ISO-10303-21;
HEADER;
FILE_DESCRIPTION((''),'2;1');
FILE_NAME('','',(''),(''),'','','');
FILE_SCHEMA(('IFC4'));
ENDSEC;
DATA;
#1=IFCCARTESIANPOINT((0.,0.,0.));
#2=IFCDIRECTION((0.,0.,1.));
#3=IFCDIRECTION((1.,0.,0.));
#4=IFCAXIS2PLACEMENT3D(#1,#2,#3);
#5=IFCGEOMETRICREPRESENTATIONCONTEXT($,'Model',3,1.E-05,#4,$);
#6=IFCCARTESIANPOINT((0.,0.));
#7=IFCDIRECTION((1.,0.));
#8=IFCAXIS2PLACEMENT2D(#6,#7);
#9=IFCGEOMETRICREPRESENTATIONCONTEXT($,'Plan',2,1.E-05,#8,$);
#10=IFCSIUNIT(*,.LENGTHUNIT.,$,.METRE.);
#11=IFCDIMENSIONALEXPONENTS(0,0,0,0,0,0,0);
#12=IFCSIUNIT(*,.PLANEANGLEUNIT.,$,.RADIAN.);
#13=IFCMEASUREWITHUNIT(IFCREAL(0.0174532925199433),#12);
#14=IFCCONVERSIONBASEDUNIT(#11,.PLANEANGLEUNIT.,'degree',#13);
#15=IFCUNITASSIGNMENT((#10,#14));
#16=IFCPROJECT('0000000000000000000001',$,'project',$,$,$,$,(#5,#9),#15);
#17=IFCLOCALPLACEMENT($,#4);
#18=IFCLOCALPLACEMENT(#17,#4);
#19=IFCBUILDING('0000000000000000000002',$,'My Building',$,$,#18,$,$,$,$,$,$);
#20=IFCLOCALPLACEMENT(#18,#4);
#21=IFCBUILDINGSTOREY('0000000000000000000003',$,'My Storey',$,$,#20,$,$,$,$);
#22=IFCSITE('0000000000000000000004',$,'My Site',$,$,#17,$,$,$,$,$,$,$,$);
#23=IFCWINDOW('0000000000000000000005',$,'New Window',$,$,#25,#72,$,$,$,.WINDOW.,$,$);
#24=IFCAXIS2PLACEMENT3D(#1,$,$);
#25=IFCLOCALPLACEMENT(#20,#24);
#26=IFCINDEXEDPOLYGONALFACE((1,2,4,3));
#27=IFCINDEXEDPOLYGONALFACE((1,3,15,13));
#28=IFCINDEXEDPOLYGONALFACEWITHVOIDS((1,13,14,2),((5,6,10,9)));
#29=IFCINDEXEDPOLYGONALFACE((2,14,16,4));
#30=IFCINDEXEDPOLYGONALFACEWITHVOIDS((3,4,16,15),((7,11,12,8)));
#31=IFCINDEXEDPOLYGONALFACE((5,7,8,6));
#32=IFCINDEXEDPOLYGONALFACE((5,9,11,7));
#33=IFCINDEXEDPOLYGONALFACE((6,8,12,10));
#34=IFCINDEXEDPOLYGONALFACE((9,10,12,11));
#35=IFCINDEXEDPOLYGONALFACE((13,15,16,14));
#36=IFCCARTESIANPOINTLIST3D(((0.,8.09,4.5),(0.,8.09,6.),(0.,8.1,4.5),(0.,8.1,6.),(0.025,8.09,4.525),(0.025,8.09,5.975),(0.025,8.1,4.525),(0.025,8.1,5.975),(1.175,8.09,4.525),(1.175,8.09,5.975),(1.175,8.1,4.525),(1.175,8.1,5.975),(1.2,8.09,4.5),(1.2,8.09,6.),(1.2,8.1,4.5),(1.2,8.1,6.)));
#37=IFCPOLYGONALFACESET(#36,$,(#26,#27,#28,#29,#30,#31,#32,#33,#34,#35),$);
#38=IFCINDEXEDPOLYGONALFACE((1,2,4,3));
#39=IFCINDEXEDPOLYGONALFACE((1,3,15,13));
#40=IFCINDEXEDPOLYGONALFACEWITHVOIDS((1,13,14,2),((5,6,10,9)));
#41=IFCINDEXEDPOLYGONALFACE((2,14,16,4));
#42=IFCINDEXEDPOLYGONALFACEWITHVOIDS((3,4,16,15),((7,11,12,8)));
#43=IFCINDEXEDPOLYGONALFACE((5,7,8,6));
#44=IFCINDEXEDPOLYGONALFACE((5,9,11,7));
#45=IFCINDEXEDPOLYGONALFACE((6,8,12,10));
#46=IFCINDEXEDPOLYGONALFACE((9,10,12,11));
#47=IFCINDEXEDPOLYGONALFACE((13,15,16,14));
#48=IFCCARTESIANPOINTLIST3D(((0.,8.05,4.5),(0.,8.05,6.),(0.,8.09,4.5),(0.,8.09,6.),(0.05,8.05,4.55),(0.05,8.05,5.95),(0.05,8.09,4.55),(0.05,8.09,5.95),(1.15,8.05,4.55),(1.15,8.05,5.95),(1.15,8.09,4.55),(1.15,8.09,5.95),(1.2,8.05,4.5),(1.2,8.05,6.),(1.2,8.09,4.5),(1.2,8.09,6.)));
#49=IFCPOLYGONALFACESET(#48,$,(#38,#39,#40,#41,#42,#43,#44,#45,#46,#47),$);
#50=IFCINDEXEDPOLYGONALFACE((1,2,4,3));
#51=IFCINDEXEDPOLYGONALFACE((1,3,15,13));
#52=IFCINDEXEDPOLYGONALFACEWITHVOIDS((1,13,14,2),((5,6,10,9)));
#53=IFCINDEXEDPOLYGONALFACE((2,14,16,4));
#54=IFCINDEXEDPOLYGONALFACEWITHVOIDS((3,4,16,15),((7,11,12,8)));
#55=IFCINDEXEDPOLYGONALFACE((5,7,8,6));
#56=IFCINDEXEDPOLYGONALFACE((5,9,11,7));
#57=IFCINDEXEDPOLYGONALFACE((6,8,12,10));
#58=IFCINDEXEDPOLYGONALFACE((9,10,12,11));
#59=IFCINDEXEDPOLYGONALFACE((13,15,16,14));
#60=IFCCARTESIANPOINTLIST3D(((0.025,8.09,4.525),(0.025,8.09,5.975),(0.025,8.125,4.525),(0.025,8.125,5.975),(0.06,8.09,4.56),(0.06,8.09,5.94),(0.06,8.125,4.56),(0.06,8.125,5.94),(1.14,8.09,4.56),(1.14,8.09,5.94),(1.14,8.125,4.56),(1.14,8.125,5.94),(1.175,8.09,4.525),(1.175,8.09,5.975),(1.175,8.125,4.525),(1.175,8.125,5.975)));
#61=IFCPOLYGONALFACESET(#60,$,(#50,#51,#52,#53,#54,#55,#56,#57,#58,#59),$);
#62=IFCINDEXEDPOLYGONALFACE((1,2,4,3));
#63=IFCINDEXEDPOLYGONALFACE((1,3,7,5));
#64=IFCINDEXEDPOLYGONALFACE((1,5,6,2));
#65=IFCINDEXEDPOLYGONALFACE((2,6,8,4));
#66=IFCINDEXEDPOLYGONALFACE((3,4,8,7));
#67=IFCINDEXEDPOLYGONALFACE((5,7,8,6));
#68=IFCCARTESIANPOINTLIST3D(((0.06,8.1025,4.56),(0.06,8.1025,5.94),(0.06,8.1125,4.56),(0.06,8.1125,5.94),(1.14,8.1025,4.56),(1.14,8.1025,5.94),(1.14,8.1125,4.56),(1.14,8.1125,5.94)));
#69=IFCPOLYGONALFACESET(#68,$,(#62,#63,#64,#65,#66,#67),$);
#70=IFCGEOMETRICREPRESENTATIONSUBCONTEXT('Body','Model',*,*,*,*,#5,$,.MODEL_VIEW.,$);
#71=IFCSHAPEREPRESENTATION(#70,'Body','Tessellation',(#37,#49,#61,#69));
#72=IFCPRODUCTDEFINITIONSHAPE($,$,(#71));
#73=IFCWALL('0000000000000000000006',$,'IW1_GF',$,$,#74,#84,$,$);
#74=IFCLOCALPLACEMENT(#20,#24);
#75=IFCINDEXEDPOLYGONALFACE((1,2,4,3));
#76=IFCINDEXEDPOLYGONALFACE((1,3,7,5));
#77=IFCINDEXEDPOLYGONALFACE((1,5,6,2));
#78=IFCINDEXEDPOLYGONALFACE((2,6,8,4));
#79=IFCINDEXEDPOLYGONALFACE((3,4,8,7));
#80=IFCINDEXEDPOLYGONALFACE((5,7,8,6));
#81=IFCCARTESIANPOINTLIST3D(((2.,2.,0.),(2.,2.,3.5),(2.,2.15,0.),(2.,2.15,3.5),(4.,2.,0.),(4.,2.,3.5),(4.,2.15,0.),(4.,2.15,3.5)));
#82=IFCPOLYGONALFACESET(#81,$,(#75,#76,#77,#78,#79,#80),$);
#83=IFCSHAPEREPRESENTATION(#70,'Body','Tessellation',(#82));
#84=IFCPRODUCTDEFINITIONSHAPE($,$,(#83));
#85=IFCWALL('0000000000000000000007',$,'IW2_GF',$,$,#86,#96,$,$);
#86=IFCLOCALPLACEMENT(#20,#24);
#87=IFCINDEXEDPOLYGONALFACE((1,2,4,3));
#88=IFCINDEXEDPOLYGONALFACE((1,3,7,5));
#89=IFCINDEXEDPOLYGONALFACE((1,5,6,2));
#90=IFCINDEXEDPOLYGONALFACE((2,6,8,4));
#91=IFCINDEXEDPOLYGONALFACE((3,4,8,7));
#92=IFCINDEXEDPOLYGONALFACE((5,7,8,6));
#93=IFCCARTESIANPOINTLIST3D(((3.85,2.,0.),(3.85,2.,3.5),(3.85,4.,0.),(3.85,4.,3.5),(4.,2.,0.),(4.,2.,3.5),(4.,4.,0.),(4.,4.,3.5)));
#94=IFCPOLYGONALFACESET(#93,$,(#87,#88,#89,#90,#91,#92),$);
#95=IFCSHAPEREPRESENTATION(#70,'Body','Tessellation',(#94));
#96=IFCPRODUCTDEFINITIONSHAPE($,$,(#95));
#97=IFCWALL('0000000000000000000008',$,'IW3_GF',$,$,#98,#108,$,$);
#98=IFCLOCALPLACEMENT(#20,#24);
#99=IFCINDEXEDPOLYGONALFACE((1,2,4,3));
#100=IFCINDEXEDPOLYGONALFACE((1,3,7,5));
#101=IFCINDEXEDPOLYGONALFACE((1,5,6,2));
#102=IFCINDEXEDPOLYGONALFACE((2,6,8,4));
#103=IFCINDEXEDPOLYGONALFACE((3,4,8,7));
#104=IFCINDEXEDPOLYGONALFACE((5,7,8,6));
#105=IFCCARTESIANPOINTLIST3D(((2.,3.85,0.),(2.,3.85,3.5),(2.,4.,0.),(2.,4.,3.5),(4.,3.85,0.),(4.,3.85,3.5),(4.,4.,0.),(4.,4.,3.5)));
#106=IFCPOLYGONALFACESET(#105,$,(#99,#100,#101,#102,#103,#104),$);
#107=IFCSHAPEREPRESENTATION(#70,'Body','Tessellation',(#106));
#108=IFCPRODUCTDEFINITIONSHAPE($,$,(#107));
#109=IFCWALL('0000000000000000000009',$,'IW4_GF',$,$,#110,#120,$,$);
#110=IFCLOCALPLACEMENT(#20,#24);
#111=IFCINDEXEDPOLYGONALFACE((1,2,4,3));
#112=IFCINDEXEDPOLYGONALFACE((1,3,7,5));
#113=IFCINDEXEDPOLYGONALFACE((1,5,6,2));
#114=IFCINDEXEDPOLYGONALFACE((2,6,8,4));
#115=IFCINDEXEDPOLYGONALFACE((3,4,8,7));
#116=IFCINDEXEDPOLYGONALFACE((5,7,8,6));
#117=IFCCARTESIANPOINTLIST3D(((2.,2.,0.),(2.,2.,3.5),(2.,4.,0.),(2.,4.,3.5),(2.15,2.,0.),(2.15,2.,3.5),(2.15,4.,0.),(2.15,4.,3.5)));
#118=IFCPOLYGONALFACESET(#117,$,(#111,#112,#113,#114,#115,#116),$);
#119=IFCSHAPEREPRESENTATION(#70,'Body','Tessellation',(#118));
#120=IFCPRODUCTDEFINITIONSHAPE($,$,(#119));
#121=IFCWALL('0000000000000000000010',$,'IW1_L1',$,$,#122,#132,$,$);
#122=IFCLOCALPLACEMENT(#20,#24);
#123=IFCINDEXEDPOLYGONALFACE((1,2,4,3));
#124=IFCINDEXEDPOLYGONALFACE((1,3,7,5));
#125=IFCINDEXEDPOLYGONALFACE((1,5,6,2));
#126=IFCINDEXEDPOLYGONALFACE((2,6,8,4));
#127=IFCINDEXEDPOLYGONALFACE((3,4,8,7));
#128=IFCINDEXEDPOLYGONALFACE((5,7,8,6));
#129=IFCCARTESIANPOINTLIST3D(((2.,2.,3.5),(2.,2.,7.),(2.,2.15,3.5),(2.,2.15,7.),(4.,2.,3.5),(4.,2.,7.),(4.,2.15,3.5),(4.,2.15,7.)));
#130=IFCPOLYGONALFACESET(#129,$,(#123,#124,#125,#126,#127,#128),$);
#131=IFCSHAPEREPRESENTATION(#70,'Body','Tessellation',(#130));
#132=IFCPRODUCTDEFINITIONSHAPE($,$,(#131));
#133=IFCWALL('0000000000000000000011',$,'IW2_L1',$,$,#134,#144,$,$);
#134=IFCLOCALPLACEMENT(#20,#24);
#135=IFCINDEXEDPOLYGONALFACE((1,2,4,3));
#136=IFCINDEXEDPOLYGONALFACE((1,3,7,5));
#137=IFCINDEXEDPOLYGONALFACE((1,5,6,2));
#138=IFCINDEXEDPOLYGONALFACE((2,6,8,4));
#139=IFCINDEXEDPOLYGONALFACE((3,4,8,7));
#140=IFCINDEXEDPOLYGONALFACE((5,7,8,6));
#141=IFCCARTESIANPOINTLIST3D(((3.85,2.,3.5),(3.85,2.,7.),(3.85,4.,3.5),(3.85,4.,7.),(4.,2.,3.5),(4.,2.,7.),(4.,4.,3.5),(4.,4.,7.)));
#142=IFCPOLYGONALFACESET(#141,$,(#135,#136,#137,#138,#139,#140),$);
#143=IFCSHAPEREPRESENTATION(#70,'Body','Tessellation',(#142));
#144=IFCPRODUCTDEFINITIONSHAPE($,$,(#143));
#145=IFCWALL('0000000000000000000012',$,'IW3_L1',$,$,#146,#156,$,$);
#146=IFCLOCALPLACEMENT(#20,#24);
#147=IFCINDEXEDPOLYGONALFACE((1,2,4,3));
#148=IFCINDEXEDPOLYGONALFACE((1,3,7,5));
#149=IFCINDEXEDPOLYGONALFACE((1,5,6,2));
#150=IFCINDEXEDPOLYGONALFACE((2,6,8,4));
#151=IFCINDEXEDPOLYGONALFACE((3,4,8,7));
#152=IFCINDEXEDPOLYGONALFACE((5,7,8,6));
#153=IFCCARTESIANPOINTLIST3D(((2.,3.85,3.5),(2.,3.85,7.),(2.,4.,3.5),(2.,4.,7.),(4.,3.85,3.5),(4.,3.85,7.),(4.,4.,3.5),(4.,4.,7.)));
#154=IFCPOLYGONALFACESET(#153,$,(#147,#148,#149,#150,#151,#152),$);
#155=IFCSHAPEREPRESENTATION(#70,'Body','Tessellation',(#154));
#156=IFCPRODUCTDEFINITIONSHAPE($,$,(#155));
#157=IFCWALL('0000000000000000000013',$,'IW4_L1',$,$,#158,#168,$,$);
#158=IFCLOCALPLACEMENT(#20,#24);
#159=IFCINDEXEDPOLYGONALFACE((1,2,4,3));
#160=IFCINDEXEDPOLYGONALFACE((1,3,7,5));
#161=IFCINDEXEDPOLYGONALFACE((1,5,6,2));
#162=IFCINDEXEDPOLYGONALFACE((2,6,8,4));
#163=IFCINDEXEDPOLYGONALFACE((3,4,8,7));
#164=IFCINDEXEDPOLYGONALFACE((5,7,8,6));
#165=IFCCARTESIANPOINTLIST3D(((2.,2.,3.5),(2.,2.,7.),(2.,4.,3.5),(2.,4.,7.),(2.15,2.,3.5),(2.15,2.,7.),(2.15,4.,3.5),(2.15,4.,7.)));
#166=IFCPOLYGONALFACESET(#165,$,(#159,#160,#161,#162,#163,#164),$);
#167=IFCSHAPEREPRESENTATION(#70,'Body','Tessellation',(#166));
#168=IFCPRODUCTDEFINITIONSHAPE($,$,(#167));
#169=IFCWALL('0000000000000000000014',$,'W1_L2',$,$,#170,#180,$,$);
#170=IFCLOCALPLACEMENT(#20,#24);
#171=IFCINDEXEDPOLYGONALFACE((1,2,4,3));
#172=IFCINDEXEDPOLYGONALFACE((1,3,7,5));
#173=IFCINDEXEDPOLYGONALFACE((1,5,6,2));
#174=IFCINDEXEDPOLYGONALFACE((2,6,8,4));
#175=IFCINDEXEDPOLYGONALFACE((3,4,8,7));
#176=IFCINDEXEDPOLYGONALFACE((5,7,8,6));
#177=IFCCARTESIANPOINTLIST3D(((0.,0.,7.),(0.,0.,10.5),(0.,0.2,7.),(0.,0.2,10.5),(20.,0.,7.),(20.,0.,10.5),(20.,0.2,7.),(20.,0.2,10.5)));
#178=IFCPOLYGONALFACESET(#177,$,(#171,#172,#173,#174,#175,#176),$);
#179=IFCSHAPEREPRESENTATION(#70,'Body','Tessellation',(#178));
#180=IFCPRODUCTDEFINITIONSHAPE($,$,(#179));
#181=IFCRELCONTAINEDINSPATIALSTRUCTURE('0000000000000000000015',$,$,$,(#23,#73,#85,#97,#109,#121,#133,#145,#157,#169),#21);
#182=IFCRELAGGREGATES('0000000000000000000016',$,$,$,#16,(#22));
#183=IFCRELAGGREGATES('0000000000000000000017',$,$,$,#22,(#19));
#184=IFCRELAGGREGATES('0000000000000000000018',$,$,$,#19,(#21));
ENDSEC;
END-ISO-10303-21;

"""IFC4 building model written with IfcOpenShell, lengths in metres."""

from ifc_helpers import new_model, entity, si_unit, converted_unit, frame, origin_with_axes, origin_2d_with_axis, place, context, subcontext, project, spatial, line, indexed_curve, outline, extrude, element, save


model = new_model("IFC4")

# Units and contexts
model_context = context("Model", 3, precision=1e-05, world=origin_with_axes())
plan_context = context("Plan", 2, precision=1e-05, world=origin_2d_with_axis())
body_context = subcontext(model_context, "Body", "Model", "MODEL_VIEW")
ifc_project = project(units=[si_unit("LENGTHUNIT", "METRE"), converted_unit("PLANEANGLEUNIT", "degree", entity("IfcReal", 0.0174532925199433), si_unit("PLANEANGLEUNIT", "RADIAN"), dimensions=[0, 0, 0, 0, 0, 0, 0])], contexts=[model_context, plan_context])

# Site, building, storey
site_placement = place(None, origin_with_axes())
site = spatial("IfcSite", under=ifc_project, at=site_placement, Name="My Site")
building_placement = place(site_placement, origin_with_axes())
building = spatial("IfcBuilding", under=site, at=building_placement, Name="My Building")
storey_placement = place(building_placement, origin_with_axes())
storey = spatial("IfcBuildingStorey", under=building, at=storey_placement, Name="My Storey")

# Window
for number, where, z_axis, x_axis, name in (
    (1, (0.0, 8.0, 4.5), (0.0, 0.0, 1.0), (1.0, 0.0, 0.0), "New Window"),
):
    element("IfcWindow", number, at=place(storey_placement, frame(where, z_axis=z_axis, x_axis=x_axis)), inside=storey, Name=name, PredefinedType="WINDOW", context=body_context, shape_type="SweptSolid", body=[
        extrude(outline(indexed_curve([(0.0, 0.0), (1.2, 0.0), (1.2, 1.5), (0.0, 1.5)], segments=[line(1, 2, 3, 4, 1)]), holes=[indexed_curve([(0.025, 0.025), (1.175, 0.025), (1.175, 1.475), (0.025, 1.475)], segments=[line(1, 2, 3, 4, 1)])]), frame((0.0, 0.09, 0.0), z_axis=(0.0, -1.0, 0.0), x_axis=(1.0, 0.0, 0.0)), (0.0, 0.0, -1.0), 0.01),
        extrude(outline(indexed_curve([(0.0, 0.0), (1.2, 0.0), (1.2, 1.5), (0.0, 1.5)], segments=[line(1, 2, 3, 4, 1)]), holes=[indexed_curve([(0.05, 0.05), (1.15, 0.05), (1.15, 1.45), (0.05, 1.45)], segments=[line(1, 2, 3, 4, 1)])]), frame((0.0, 0.05, 0.0), z_axis=(0.0, -1.0, 0.0), x_axis=(1.0, 0.0, 0.0)), (0.0, 0.0, -1.0), 0.04),
        extrude(outline(indexed_curve([(0.0, 0.0), (1.15, 0.0), (1.15, 1.45), (0.0, 1.45)], segments=[line(1, 2, 3, 4, 1)]), holes=[indexed_curve([(0.035, 0.035), (1.115, 0.035), (1.115, 1.415), (0.035, 1.415)], segments=[line(1, 2, 3, 4, 1)])]), frame((0.025, 0.09, 0.025), z_axis=(0.0, -1.0, 0.0), x_axis=(1.0, 0.0, 0.0)), (0.0, 0.0, -1.0), 0.035),
        extrude(outline(indexed_curve([(0.035, 0.035), (1.115, 0.035), (1.115, 1.415), (0.035, 1.415)], segments=[line(1, 2, 3, 4, 1)])), frame((0.025, 0.1025, 0.025), z_axis=(0.0, -1.0, 0.0), x_axis=(1.0, 0.0, 0.0)), (0.0, 0.0, -1.0), 0.01),
    ])

# Walls
for number, where, z_axis, x_axis, name in (
    (2, (2.0, 2.0, 0.0), (0.0, 0.0, 1.0), (1.0, 0.0, 0.0), "IW1_GF"),
    (3, (4.0, 2.0, 0.0), (0.0, 0.0, 1.0), (0.0, 1.0, 0.0), "IW2_GF"),
    (4, (4.0, 4.0, 0.0), (0.0, 0.0, 1.0), (-1.0, 0.0, 0.0), "IW3_GF"),
    (5, (2.0, 4.0, 0.0), (0.0, 0.0, 1.0), (0.0, -1.0, 0.0), "IW4_GF"),
):
    element("IfcWall", number, at=place(storey_placement, frame(where, z_axis=z_axis, x_axis=x_axis)), inside=storey, Name=name, context=body_context, shape_type="SweptSolid", body=[
        extrude(outline(indexed_curve([(0.0, 0.0), (0.0, 0.15), (2.0, 0.15), (2.0, 0.0), (0.0, 0.0)], self_intersect=False)), origin_with_axes(), (0.0, 0.0, 1.0), 3.5),
    ])
for number, where, z_axis, x_axis, name in (
    (6, (2.0, 2.0, 3.5), (0.0, 0.0, 1.0), (1.0, 0.0, 0.0), "IW1_L1"),
    (7, (4.0, 2.0, 3.5), (0.0, 0.0, 1.0), (0.0, 1.0, 0.0), "IW2_L1"),
    (8, (4.0, 4.0, 3.5), (0.0, 0.0, 1.0), (-1.0, 0.0, 0.0), "IW3_L1"),
    (9, (2.0, 4.0, 3.5), (0.0, 0.0, 1.0), (0.0, -1.0, 0.0), "IW4_L1"),
):
    element("IfcWall", number, at=place(storey_placement, frame(where, z_axis=z_axis, x_axis=x_axis)), inside=storey, Name=name, context=body_context, shape_type="SweptSolid", body=[
        extrude(outline(indexed_curve([(0.0, 0.0), (0.0, 0.15), (2.0, 0.15), (2.0, 0.0), (0.0, 0.0)], self_intersect=False)), origin_with_axes(), (0.0, 0.0, 1.0), 3.5),
    ])
wall_1_placement = place(storey_placement, frame((0.0, 0.0, 7.0), z_axis=(0.0, 0.0, 1.0), x_axis=(1.0, 0.0, 0.0)))
element("IfcWall", 10, at=wall_1_placement, inside=storey, Name="W1_L2", context=body_context, shape_type="SweptSolid", body=[
    extrude(outline(indexed_curve([(0.0, 0.0), (0.0, 0.2), (20.0, 0.2), (20.0, 0.0), (0.0, 0.0)], self_intersect=False)), origin_with_axes(), (0.0, 0.0, 1.0), 3.5),
])

save(model, "model.ifc")
